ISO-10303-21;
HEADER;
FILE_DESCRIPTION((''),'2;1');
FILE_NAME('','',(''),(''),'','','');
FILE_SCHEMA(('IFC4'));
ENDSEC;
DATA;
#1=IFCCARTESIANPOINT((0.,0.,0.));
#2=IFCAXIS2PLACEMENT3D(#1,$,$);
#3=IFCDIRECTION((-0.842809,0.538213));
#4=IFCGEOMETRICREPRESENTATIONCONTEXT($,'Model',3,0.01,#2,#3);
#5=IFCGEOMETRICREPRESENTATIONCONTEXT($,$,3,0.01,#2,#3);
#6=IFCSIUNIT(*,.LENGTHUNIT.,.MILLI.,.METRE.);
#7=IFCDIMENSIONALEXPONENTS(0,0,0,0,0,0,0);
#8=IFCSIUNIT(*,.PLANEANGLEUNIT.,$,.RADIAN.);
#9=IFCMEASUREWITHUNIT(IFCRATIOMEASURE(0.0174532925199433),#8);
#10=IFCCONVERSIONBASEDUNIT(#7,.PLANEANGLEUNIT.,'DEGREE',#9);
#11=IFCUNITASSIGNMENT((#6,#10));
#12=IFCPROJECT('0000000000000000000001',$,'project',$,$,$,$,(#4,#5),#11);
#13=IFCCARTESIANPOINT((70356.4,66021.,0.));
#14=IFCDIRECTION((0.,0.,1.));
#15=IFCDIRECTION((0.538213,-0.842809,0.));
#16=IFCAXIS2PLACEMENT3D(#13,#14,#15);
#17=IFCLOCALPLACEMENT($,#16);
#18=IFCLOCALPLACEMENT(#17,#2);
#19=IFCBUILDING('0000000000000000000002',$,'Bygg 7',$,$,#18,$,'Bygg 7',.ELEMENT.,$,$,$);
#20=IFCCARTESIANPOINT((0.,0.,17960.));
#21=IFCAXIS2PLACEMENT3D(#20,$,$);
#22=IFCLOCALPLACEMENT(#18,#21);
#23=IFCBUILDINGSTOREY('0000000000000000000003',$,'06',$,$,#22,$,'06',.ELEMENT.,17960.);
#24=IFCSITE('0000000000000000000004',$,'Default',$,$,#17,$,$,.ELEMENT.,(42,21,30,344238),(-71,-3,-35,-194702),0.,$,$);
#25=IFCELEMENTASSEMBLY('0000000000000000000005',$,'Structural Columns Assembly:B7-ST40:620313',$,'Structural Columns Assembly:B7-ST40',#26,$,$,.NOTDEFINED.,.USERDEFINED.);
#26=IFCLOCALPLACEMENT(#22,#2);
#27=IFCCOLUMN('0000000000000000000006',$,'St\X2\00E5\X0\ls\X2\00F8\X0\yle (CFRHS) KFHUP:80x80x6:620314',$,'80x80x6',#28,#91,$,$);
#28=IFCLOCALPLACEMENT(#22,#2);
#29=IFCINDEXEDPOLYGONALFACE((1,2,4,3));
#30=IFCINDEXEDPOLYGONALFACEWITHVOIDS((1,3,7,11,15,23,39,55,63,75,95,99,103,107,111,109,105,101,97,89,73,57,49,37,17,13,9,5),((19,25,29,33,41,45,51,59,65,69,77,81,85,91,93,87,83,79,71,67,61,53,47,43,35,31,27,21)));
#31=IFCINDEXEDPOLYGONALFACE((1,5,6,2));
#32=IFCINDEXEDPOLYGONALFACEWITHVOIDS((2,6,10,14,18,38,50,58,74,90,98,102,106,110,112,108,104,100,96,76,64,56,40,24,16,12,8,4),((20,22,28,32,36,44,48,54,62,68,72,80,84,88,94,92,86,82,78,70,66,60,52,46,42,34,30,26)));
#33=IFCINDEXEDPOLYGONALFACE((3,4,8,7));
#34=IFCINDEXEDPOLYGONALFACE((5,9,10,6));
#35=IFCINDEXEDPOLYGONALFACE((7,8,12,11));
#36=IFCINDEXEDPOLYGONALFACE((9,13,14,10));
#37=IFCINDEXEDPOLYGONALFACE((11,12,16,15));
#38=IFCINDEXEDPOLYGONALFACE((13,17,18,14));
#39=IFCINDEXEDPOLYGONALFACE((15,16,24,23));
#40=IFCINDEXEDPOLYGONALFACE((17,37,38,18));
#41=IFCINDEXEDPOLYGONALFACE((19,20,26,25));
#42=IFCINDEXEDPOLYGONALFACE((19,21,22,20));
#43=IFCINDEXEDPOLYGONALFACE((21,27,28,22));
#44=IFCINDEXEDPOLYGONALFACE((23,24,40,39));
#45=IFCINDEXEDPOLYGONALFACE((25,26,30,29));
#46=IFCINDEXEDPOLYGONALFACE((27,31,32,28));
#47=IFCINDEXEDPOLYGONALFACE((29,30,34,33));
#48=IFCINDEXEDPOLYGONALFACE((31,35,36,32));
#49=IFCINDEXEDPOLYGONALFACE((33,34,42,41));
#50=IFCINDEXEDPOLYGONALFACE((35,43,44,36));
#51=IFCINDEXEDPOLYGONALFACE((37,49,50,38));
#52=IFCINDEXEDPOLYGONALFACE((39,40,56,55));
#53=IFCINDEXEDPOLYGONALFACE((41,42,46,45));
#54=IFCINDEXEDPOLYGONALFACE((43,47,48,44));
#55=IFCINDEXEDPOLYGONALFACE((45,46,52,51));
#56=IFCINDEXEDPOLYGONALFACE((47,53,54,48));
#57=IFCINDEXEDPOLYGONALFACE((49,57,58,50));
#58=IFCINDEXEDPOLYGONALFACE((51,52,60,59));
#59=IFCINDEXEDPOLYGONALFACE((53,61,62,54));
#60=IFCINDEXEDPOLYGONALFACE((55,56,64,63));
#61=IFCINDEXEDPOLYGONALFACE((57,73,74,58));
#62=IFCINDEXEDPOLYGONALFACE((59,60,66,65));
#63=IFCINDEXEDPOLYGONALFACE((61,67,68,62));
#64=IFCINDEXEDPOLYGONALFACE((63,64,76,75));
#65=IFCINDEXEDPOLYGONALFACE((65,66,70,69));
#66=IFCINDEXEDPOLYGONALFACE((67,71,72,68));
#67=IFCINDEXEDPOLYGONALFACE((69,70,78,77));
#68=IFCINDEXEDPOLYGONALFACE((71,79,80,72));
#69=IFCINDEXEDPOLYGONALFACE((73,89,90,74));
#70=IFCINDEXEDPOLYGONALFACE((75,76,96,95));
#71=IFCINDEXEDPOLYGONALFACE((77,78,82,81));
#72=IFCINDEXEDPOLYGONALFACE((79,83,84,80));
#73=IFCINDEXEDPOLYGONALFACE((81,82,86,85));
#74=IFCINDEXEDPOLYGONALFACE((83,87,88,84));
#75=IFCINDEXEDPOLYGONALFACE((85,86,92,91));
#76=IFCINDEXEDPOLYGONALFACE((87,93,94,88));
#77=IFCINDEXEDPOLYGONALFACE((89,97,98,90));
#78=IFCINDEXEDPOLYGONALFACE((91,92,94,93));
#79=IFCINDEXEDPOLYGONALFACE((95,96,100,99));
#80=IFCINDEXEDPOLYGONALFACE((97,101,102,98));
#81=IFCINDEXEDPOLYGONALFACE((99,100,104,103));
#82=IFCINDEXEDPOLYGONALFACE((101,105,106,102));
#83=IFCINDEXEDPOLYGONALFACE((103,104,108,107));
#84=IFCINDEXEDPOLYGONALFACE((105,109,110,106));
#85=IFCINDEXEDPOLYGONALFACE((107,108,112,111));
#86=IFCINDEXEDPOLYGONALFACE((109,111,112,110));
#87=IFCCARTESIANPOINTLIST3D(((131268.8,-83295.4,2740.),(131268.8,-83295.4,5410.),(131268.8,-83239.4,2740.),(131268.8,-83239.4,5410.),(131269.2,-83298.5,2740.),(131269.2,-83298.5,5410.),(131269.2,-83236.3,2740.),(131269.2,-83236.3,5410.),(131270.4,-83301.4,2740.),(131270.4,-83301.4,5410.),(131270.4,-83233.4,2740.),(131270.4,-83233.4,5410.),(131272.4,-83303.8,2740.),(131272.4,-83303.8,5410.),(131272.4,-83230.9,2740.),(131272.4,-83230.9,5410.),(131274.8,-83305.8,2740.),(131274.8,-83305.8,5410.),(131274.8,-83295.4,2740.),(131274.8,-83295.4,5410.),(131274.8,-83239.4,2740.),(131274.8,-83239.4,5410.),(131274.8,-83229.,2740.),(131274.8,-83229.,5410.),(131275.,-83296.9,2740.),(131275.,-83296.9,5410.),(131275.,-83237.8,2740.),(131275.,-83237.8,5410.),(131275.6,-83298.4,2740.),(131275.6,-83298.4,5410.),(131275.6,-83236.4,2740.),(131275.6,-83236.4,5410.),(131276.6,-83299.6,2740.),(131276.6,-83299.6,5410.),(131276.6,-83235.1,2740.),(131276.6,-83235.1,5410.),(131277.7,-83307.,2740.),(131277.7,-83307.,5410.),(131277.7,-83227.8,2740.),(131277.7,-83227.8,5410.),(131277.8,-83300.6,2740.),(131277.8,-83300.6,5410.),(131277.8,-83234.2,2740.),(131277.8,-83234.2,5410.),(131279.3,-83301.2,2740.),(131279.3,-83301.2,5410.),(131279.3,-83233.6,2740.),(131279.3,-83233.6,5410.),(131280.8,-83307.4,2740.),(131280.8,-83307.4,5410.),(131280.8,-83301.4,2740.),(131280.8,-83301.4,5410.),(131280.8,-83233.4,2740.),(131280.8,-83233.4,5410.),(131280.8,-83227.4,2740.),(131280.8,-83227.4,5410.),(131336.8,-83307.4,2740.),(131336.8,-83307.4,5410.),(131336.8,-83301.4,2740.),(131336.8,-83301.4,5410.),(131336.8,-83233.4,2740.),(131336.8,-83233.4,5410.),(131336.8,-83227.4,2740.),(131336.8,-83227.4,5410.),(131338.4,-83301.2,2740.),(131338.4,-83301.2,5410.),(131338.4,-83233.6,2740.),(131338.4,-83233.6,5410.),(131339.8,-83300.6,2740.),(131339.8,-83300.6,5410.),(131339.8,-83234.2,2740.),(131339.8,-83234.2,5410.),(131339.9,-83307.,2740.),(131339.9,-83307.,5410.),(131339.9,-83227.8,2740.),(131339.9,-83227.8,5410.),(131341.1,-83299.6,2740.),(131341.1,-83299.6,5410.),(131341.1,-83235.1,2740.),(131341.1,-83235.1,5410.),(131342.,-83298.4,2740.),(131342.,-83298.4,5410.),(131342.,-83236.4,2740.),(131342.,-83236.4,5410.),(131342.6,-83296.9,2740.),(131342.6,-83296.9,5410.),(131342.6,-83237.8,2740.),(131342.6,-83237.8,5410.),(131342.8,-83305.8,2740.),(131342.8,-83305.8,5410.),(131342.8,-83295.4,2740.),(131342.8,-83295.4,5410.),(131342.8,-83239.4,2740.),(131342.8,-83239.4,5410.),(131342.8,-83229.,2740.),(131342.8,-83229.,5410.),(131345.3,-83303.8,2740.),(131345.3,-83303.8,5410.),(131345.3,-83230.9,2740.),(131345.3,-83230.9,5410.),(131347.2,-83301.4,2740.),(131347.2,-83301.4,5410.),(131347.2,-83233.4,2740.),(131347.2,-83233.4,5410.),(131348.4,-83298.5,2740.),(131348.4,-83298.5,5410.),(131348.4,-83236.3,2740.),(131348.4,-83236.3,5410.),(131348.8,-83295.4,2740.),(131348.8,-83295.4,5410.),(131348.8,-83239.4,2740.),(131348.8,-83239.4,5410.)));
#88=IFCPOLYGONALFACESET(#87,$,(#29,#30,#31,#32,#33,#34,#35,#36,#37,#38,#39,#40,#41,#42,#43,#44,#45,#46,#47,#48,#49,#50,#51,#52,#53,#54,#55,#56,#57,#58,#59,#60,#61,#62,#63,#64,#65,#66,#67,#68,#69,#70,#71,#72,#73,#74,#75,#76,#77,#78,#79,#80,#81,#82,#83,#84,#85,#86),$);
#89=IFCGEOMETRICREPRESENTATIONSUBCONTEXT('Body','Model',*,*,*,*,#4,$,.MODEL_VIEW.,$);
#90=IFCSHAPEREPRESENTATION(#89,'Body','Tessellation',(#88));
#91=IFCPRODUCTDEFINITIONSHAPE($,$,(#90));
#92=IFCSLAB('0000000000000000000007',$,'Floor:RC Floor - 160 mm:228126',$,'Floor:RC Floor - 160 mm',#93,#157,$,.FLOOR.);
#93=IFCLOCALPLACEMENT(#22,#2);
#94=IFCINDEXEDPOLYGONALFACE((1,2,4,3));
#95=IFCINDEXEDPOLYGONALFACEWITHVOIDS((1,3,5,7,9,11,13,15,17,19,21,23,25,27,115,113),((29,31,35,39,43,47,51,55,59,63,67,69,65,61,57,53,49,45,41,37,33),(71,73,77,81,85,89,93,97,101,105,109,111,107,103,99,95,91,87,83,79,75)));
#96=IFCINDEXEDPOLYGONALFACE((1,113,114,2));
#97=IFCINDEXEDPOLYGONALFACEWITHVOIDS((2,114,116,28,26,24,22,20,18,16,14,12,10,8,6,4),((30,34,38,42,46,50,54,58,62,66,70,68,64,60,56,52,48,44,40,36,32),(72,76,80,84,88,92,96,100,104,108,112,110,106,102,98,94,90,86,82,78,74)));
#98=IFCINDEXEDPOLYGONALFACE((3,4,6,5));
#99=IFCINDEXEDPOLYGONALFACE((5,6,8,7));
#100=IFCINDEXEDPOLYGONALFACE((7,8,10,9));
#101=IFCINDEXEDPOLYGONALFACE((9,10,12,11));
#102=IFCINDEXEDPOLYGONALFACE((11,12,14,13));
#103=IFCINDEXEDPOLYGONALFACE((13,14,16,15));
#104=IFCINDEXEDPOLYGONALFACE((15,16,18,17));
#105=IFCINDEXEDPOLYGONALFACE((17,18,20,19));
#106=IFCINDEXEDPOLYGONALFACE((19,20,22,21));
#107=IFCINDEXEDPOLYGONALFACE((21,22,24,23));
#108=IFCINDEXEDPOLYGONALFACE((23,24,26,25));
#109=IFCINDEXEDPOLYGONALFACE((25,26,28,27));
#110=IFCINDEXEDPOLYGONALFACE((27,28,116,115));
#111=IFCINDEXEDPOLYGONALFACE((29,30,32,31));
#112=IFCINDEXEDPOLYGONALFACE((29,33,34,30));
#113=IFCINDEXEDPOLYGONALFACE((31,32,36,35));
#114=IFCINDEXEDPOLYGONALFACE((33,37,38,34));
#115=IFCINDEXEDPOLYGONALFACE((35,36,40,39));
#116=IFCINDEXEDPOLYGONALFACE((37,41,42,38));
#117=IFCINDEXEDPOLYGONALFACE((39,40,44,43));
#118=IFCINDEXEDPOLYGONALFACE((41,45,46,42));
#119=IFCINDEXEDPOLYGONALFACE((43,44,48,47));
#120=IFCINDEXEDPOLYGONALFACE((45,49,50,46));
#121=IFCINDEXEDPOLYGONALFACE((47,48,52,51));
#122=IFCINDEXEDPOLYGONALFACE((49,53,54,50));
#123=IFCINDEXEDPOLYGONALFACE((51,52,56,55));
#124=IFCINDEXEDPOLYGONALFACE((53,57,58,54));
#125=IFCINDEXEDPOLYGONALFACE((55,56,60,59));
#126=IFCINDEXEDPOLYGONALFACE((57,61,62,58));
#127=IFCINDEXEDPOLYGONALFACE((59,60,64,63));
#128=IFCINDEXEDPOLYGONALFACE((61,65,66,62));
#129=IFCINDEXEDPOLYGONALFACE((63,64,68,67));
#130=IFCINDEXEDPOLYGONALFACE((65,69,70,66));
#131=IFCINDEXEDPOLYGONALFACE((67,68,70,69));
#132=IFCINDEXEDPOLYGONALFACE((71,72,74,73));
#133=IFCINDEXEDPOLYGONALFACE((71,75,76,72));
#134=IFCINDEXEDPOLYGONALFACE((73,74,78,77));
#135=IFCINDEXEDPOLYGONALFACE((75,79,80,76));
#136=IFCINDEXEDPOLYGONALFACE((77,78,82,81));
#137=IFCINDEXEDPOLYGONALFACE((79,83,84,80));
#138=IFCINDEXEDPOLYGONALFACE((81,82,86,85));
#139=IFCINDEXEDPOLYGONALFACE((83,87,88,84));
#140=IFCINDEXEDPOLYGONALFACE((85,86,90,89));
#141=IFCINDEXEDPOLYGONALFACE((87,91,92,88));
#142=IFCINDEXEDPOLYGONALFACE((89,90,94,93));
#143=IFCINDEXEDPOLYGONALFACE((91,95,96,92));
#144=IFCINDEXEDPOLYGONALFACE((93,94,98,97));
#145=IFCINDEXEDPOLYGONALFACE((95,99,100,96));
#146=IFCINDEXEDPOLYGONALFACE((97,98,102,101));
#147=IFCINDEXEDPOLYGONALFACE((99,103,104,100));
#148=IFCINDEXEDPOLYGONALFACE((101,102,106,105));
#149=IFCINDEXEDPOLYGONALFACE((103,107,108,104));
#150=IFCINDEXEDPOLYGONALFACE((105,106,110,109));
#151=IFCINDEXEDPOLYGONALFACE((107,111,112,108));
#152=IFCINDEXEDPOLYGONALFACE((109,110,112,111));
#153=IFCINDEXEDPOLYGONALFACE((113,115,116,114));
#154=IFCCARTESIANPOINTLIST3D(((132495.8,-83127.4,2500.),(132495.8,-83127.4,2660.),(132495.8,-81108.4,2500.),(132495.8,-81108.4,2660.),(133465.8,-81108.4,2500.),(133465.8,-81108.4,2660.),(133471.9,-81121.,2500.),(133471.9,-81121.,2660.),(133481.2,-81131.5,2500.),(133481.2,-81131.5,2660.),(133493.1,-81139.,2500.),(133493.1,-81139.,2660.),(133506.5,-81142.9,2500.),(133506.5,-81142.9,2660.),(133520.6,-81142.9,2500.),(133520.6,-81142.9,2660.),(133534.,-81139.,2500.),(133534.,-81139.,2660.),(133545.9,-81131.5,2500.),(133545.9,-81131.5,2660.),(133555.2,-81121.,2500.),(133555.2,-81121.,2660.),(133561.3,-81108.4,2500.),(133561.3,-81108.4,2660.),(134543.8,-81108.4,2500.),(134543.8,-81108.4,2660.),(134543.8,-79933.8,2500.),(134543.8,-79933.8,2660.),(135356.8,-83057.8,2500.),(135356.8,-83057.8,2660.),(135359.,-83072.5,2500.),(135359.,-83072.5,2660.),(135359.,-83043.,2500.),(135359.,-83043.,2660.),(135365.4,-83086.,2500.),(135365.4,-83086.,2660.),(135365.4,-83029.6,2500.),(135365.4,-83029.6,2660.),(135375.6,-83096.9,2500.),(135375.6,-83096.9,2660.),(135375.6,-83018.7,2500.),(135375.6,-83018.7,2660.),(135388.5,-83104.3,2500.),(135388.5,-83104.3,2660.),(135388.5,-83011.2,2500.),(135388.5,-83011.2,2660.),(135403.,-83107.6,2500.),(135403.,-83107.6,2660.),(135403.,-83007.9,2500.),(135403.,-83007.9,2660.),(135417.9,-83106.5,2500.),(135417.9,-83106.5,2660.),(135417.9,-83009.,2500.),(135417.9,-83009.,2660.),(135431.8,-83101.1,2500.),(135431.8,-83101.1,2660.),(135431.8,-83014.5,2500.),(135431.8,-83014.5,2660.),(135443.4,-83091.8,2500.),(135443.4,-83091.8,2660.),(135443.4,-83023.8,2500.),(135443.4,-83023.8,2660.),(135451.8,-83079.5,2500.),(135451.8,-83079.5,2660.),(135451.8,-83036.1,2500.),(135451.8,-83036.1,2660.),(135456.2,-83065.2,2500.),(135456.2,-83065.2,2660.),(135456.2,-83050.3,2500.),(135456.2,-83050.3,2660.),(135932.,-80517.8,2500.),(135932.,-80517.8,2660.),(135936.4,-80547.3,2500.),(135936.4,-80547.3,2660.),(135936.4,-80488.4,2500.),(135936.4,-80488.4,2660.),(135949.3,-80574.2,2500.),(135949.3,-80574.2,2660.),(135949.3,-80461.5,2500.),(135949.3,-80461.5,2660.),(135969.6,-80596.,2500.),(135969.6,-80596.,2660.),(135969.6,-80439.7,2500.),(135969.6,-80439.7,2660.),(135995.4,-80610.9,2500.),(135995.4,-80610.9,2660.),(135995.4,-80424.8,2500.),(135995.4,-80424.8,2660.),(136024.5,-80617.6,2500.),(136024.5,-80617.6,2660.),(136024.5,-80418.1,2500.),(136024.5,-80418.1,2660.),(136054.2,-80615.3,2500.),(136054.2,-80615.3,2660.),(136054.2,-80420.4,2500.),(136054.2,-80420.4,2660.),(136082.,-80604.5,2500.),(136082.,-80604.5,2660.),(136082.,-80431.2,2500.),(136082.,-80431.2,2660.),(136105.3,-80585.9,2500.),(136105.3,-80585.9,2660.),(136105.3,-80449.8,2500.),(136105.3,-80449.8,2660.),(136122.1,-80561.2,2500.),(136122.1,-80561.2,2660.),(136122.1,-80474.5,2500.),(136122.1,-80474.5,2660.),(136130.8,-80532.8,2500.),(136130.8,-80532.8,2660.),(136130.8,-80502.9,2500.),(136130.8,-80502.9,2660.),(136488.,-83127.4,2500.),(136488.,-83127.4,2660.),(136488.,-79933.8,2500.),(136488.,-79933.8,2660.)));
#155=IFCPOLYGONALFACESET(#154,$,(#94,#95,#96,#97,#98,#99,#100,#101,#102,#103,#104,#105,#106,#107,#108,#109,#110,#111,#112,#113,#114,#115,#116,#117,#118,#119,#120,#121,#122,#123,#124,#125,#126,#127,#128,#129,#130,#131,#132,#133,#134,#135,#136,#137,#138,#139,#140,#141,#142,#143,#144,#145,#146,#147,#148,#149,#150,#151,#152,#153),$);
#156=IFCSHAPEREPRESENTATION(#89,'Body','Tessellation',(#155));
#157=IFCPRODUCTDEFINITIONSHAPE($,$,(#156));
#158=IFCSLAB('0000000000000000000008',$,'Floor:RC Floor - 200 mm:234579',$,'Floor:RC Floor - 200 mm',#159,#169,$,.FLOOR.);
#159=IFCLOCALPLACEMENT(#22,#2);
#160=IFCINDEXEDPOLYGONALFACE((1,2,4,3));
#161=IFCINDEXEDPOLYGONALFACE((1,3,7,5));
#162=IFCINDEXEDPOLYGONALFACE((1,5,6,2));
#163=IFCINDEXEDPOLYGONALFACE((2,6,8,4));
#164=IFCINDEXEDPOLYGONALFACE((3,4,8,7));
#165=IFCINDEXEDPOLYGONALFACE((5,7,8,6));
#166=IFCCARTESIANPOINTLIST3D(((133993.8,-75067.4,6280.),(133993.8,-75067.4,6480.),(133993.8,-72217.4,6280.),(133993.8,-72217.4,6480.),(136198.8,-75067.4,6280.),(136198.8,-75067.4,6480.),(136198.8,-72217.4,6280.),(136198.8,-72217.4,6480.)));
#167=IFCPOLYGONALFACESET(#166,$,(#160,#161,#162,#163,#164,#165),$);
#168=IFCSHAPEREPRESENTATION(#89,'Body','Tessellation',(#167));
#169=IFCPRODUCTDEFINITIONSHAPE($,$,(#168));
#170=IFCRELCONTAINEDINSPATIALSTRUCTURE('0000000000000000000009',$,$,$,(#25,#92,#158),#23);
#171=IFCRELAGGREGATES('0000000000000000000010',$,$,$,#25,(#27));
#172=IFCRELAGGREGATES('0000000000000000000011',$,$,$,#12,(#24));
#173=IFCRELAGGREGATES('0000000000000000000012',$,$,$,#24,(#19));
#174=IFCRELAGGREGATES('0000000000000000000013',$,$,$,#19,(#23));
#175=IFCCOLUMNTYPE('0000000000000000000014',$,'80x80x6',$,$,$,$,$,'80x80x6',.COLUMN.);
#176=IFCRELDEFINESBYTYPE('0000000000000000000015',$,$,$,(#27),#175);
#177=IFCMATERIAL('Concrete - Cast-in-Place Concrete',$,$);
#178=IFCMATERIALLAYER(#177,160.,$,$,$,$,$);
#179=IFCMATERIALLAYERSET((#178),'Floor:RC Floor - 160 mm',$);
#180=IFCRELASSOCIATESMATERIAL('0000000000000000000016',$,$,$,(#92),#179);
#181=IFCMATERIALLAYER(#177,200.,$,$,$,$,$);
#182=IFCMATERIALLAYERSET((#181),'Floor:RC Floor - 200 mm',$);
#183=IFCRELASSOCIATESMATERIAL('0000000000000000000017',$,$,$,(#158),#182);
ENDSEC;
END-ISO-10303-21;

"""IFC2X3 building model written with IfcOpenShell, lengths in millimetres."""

from ifc_helpers import new_model, entity, si_unit, converted_unit, direction, frame, frame_2d, origin, place, context, subcontext, project, spatial, polyline, circle_curve, parameter, trimmed, segment, composite_curve, rectangle, circle, outline, extrude, source, transform, mapped, material, layer, layer_set, layer_usage, type_object, type_shapes, element, aggregate, save


model = new_model("IFC2X3")

# Units and contexts
model_context = context("Model", 3, precision=0.01, world=origin(), true_north=direction((-0.842809, 0.538213)))
context_of_model = context(None, 3, precision=0.01, world=origin(), true_north=direction((-0.842809, 0.538213)))
body_context = subcontext(model_context, "Body", "Model", "MODEL_VIEW")
ifc_project = project(units=[si_unit("LENGTHUNIT", "METRE", prefix="MILLI"), converted_unit("PLANEANGLEUNIT", "DEGREE", entity("IfcRatioMeasure", 0.0174532925199433), si_unit("PLANEANGLEUNIT", "RADIAN"), dimensions=[0, 0, 0, 0, 0, 0, 0])], contexts=[model_context, context_of_model])

# Site, building, storey
site_placement = place(None, frame((70356.4, 66021.0, 0.0), z_axis=(0.0, 0.0, 1.0), x_axis=(0.538213, -0.842809, 0.0)))
site = spatial("IfcSite", under=ifc_project, at=site_placement, Name="Default", CompositionType="ELEMENT", RefLatitude=(42, 21, 30, 344238), RefLongitude=(-71, -3, -35, -194702), RefElevation=0.0)
building_placement = place(site_placement, origin())
building = spatial("IfcBuilding", under=site, at=building_placement, Name="Bygg 7", LongName="Bygg 7", CompositionType="ELEMENT")
storey_placement = place(building_placement, frame((0.0, 0.0, 17960.0)))
storey = spatial("IfcBuildingStorey", under=building, at=storey_placement, Name="06", LongName="06", CompositionType="ELEMENT", Elevation=17960.0)

# Element assembly, column
assembly_1_placement = place(storey_placement, origin())
assembly_1 = element("IfcElementAssembly", 1, at=assembly_1_placement, inside=storey, Name="Structural Columns Assembly:B7-ST40:620313", ObjectType="Structural Columns Assembly:B7-ST40", AssemblyPlace="NOTDEFINED", PredefinedType="USERDEFINED")
column_type_1 = type_object("IfcColumnType", Name="80x80x6", ElementType="80x80x6", PredefinedType="COLUMN")
shared_shape_1 = source(origin(), body_context, "Body", "SweptSolid", [
    extrude(outline(composite_curve([segment(trimmed(circle_curve(frame_2d((-28.0, 28.0), x_axis=(1.0, 0.0)), 12.0), [parameter(90.0)], [parameter(180.0)], True, "PARAMETER"), True, "CONTINUOUS"), segment(polyline([(-40.0, 28.0), (-40.0, -28.0)]), True, "CONTINUOUS"), segment(trimmed(circle_curve(frame_2d((-28.0, -28.0), x_axis=(1.0, 0.0)), 12.0), [parameter(180.0)], [parameter(270.0)], True, "PARAMETER"), True, "CONTINUOUS"), segment(polyline([(-28.0, -40.0), (28.0, -40.0)]), True, "CONTINUOUS"), segment(trimmed(circle_curve(frame_2d((28.0, -28.0), x_axis=(1.0, 0.0)), 12.0), [parameter(270.0)], [parameter(0.0)], True, "PARAMETER"), True, "CONTINUOUS"), segment(polyline([(40.0, -28.0), (40.0, 28.0)]), True, "CONTINUOUS"), segment(trimmed(circle_curve(frame_2d((28.0, 28.0), x_axis=(1.0, 0.0)), 12.0), [parameter(0.0)], [parameter(90.0)], True, "PARAMETER"), True, "CONTINUOUS"), segment(polyline([(28.0, 40.0), (-28.0, 40.0)]), True, "CONTINUOUS")], self_intersect=False), holes=[composite_curve([segment(polyline([(-28.0, 34.0), (28.0, 34.0)]), True, "CONTINUOUS"), segment(trimmed(circle_curve(frame_2d((28.0, 28.0), x_axis=(1.0, 0.0)), 6.0), [parameter(360.0)], [parameter(90.0)], True, "PARAMETER"), False, "CONTINUOUS"), segment(polyline([(34.0, 28.0), (34.0, -28.0)]), True, "CONTINUOUS"), segment(trimmed(circle_curve(frame_2d((28.0, -28.0), x_axis=(1.0, 0.0)), 6.0), [parameter(270.0)], [parameter(360.0)], True, "PARAMETER"), False, "CONTINUOUS"), segment(polyline([(28.0, -34.0), (-28.0, -34.0)]), True, "CONTINUOUS"), segment(trimmed(circle_curve(frame_2d((-28.0, -28.0), x_axis=(1.0, 0.0)), 6.0), [parameter(180.0)], [parameter(270.0)], True, "PARAMETER"), False, "CONTINUOUS"), segment(polyline([(-34.0, -28.0), (-34.0, 28.0)]), True, "CONTINUOUS"), segment(trimmed(circle_curve(frame_2d((-28.0, 28.0), x_axis=(1.0, 0.0)), 6.0), [parameter(90.0)], [parameter(180.0)], True, "PARAMETER"), False, "CONTINUOUS")], self_intersect=False)]), frame((41.6, 41.6, 0.0), z_axis=(0.0, 0.0, 1.0), x_axis=(0.0, -1.0, 0.0)), (0.0, 0.0, 1.0), 2670.0),
])
type_shapes(column_type_1, [shared_shape_1])
column_1_placement = place(assembly_1_placement, frame((131267.2, -83309.0, 2740.0)))
column_1 = element("IfcColumn", 2, at=column_1_placement, type_object=column_type_1, Name="Stålsøyle (CFRHS) KFHUP:80x80x6:620314", ObjectType="80x80x6", context=body_context, shape_type="MappedRepresentation", body=[
    mapped(shared_shape_1, transform((0.0, 0.0, 0.0), scale=1.0)),
])

# Slab, openings
ifc_material_1 = material(Name="Concrete - Cast-in-Place Concrete")
ifc_layer_1 = layer(ifc_material_1, 160.0)
ifc_layer_set_1 = layer_set([ifc_layer_1], Name="Floor:RC Floor - 160 mm")
ifc_layer_usage_1 = layer_usage(ifc_layer_set_1, "AXIS3", "POSITIVE", 0.0)
slab_1_placement = place(storey_placement, frame((132495.8, -83127.4, 2500.0)))
slab_1 = element("IfcSlab", 3, at=slab_1_placement, inside=storey, material=ifc_layer_usage_1, Name="Floor:RC Floor - 160 mm:228126", ObjectType="Floor:RC Floor - 160 mm", PredefinedType="FLOOR", context=body_context, shape_type="SweptSolid", body=[
    extrude(outline(polyline([(1996.1, -1596.8), (1996.1, 422.2), (-51.9, 422.2), (-51.9, 1596.8), (-1996.1, 1596.8), (-1996.1, -1596.8), (1996.1, -1596.8)])), frame((1996.1, 1596.8, 160.0), z_axis=(0.0, 0.0, -1.0), x_axis=(-1.0, 0.0, 0.0)), (0.0, 0.0, 1.0), 160.0),
])
opening_1_placement = place(storey_placement, frame((132495.8, -83127.4, 2500.0)))
element("IfcOpeningElement", 4, at=opening_1_placement, cuts=slab_1, ObjectType="Opening", context=body_context, shape_type="SweptSolid", body=[
    extrude(circle(Radius=50.0, at=frame_2d((-914.9, -1527.2), x_axis=(1.0, 0.0))), frame((1996.1, 1596.8, 160.0), z_axis=(0.0, 0.0, -1.0), x_axis=(-1.0, 0.0, 0.0)), (0.0, 0.0, 1.0), 160.0),
])
opening_2_placement = place(storey_placement, frame((132495.8, -83127.4, 2500.0)))
element("IfcOpeningElement", 5, at=opening_2_placement, cuts=slab_1, ObjectType="Opening", context=body_context, shape_type="SweptSolid", body=[
    extrude(circle(Radius=100.0, at=frame_2d((-1540.0, 1012.7), x_axis=(1.0, 0.0))), frame((1996.1, 1596.8, 160.0), z_axis=(0.0, 0.0, -1.0), x_axis=(-1.0, 0.0, 0.0)), (0.0, 0.0, 1.0), 160.0),
])
opening_3_placement = place(storey_placement, frame((132495.8, -83127.4, 2500.0)))
element("IfcOpeningElement", 6, at=opening_3_placement, cuts=slab_1, ObjectType="Opening", context=body_context, shape_type="SweptSolid", body=[
    extrude(circle(Radius=50.0, at=frame_2d((978.4, 437.2), x_axis=(1.0, 0.0))), frame((1996.1, 1596.8, 160.0), z_axis=(0.0, 0.0, -1.0), x_axis=(-1.0, 0.0, 0.0)), (0.0, 0.0, 1.0), 160.0),
])

# Slab
ifc_layer_2 = layer(ifc_material_1, 200.0)
ifc_layer_set_2 = layer_set([ifc_layer_2], Name="Floor:RC Floor - 200 mm")
ifc_layer_usage_2 = layer_usage(ifc_layer_set_2, "AXIS3", "POSITIVE", 0.0)
slab_2_placement = place(storey_placement, origin())
element("IfcSlab", 7, at=slab_2_placement, inside=storey, material=ifc_layer_usage_2, Name="Floor:RC Floor - 200 mm:234579", ObjectType="Floor:RC Floor - 200 mm", PredefinedType="FLOOR", context=body_context, shape_type="SweptSolid", body=[
    extrude(rectangle(XDim=2850.0, YDim=2205.0, at=frame_2d((0.0, 0.0), x_axis=(1.0, 0.0))), frame((135096.3, -73642.4, 6480.0), z_axis=(0.0, 0.0, -1.0), x_axis=(0.0, 1.0, 0.0)), (0.0, 0.0, 1.0), 200.0),
])

aggregate(assembly_1, [column_1])

save(model, "model.ifc")
